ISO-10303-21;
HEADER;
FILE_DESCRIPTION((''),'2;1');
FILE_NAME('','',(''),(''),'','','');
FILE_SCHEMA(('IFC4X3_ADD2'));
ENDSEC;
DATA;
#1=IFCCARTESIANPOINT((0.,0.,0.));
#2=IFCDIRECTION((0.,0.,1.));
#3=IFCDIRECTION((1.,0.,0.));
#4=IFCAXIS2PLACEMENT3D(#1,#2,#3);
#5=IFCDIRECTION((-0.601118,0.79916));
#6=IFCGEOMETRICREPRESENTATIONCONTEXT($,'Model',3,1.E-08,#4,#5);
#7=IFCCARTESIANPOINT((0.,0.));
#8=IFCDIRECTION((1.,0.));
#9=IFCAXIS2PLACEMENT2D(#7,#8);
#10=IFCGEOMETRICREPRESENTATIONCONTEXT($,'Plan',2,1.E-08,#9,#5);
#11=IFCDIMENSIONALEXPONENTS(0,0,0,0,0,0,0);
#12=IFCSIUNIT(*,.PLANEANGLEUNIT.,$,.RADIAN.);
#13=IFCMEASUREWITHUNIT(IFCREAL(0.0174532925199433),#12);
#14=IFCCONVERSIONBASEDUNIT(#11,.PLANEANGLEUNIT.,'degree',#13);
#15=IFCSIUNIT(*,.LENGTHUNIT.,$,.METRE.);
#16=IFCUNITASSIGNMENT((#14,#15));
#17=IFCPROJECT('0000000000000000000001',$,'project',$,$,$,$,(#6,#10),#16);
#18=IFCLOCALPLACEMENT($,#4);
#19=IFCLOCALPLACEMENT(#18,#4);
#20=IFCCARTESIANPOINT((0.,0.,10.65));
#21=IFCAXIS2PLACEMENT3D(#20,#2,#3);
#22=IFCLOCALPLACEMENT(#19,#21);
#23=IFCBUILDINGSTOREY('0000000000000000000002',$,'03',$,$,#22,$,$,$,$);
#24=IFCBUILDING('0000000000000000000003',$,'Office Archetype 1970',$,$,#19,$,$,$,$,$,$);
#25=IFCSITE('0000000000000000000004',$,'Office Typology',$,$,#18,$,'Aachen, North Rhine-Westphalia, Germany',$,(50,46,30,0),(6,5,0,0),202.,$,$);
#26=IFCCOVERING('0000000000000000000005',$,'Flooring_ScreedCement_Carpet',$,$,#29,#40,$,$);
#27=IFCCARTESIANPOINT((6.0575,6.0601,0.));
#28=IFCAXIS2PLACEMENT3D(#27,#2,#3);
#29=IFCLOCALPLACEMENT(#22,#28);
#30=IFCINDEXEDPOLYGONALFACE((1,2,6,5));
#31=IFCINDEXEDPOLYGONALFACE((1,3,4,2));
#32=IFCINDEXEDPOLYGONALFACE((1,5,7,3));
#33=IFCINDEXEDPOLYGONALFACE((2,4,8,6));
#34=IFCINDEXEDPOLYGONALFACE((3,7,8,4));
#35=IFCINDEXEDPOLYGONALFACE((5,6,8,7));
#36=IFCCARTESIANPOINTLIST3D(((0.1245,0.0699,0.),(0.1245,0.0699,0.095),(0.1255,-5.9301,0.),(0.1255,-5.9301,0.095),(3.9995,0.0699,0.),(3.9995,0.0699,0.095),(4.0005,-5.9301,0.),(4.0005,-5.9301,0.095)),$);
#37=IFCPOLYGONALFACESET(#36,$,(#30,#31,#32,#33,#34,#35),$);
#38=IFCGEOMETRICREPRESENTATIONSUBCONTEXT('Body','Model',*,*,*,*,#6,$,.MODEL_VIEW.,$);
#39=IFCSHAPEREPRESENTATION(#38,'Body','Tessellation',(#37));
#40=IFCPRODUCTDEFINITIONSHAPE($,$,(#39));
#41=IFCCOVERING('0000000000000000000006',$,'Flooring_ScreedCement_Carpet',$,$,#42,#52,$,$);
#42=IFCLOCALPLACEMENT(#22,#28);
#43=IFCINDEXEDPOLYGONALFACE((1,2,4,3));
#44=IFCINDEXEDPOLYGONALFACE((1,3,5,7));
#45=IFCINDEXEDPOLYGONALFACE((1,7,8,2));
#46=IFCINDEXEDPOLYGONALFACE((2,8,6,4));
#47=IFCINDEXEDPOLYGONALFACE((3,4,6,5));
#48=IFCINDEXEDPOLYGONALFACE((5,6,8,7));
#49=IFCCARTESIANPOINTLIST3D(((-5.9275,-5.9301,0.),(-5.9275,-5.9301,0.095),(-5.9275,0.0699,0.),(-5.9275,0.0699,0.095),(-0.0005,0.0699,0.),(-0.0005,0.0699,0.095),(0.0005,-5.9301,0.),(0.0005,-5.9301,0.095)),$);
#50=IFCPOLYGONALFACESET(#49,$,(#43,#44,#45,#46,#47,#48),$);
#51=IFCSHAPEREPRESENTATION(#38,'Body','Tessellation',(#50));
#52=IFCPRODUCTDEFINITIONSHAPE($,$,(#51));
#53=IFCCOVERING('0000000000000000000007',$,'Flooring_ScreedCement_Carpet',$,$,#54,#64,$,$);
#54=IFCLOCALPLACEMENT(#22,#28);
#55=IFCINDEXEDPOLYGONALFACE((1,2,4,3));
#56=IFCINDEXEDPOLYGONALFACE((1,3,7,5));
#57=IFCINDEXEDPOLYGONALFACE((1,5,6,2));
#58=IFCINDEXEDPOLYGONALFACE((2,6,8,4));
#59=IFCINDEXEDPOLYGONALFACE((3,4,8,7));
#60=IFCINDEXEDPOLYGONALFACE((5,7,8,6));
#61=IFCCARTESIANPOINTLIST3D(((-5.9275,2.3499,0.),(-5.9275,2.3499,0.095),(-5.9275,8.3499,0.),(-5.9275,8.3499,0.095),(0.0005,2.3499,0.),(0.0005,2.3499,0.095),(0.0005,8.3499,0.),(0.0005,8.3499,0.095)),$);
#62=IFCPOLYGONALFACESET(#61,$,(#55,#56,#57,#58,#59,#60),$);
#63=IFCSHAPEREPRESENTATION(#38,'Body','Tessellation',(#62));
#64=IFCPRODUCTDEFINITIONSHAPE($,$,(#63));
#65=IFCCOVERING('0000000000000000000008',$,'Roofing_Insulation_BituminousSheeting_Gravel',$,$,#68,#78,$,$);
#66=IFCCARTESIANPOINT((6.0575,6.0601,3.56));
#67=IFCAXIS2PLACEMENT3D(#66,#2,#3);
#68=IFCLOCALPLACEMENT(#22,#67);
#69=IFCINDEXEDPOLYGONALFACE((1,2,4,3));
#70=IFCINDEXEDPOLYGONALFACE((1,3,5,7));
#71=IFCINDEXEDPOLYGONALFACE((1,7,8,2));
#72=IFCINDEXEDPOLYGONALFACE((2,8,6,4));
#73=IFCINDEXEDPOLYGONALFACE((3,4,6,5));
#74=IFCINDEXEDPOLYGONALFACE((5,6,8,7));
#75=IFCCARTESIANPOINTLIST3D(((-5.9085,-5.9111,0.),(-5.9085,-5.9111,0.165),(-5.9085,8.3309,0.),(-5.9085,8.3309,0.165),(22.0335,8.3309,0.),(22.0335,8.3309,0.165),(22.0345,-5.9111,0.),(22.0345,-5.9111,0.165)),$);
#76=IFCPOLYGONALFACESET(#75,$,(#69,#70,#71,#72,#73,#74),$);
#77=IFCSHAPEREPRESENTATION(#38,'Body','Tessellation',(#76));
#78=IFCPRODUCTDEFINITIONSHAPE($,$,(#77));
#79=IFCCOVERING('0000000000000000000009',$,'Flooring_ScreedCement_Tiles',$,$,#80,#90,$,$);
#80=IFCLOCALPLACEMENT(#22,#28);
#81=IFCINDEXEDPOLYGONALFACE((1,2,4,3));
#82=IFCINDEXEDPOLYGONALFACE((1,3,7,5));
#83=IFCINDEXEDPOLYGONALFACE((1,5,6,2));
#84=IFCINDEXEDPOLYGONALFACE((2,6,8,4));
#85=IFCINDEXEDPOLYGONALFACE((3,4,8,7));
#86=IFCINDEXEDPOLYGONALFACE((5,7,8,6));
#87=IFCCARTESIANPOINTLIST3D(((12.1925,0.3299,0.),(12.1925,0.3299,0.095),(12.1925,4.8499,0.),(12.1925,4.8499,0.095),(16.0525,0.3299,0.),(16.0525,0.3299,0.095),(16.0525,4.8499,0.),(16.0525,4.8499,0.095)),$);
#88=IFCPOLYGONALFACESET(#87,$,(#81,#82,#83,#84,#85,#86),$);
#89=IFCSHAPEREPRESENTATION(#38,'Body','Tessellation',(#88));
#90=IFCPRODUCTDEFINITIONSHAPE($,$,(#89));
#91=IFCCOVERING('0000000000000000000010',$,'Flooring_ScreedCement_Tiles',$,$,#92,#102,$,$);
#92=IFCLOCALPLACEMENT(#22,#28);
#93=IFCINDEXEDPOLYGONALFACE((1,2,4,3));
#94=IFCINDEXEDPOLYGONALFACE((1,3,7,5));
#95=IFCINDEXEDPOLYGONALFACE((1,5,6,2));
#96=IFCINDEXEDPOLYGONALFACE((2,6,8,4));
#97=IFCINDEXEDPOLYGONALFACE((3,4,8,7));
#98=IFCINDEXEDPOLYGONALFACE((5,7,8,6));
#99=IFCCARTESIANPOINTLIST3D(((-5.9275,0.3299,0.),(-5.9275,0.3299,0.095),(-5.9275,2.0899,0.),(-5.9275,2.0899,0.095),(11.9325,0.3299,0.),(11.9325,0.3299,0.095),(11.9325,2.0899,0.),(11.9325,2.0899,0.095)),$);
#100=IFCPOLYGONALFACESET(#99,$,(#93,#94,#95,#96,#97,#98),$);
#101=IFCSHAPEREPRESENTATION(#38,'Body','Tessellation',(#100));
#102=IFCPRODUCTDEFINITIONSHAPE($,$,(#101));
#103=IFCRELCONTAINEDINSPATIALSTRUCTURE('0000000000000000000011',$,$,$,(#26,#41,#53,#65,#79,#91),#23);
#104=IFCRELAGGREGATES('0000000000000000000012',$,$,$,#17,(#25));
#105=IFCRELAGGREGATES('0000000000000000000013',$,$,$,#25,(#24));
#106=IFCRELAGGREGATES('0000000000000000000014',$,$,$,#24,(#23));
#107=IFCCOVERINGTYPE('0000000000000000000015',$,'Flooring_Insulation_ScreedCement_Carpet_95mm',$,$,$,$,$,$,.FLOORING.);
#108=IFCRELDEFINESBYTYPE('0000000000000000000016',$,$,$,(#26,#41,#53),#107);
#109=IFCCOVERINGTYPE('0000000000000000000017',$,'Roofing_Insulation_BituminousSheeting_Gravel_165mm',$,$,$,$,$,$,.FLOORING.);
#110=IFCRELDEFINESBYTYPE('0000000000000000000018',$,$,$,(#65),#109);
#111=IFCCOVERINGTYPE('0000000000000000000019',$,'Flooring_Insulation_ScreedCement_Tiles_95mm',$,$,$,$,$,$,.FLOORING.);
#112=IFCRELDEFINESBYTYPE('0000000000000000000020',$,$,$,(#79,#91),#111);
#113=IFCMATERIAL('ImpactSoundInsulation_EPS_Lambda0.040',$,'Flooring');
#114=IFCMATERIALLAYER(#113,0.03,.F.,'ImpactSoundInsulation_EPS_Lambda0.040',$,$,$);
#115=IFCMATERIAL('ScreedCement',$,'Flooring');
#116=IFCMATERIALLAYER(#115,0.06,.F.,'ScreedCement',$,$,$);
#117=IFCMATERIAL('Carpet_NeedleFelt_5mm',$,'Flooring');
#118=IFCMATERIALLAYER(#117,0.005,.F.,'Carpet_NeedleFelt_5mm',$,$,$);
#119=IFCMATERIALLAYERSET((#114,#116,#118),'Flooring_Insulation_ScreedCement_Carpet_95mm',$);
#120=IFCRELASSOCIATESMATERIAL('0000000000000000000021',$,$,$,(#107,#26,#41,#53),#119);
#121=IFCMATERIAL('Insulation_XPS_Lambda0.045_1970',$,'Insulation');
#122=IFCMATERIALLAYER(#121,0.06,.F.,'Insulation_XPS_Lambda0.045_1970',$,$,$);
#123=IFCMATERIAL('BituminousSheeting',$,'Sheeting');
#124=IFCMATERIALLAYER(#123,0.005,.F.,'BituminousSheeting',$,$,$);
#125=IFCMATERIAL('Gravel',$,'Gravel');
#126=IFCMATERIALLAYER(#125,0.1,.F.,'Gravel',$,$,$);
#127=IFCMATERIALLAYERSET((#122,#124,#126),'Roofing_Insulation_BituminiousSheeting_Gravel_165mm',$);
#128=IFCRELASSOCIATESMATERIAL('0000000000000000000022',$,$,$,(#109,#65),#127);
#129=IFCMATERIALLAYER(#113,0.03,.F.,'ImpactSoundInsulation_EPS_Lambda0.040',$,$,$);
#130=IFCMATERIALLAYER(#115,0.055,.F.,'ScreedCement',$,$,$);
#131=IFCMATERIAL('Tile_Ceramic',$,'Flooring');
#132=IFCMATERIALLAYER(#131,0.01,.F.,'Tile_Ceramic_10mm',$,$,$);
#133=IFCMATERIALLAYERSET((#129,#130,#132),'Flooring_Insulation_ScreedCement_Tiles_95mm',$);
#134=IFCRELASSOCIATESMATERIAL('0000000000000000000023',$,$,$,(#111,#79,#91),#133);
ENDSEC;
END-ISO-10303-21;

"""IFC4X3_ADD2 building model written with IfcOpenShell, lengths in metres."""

from ifc_helpers import new_model, entity, si_unit, converted_unit, direction, frame, origin_with_axes, origin_2d_with_axis, place, context, subcontext, project, spatial, line, indexed_curve, outline, extrude, material, layer, layer_set, layer_usage, type_object, element, save


model = new_model("IFC4X3_ADD2")

# Units and contexts
model_context = context("Model", 3, precision=1e-08, world=origin_with_axes(), true_north=direction((-0.601118, 0.79916)))
plan_context = context("Plan", 2, precision=1e-08, world=origin_2d_with_axis(), true_north=direction((-0.601118, 0.79916)))
body_context = subcontext(model_context, "Body", "Model", "MODEL_VIEW")
ifc_project = project(units=[converted_unit("PLANEANGLEUNIT", "degree", entity("IfcReal", 0.0174532925199433), si_unit("PLANEANGLEUNIT", "RADIAN"), dimensions=[0, 0, 0, 0, 0, 0, 0]), si_unit("LENGTHUNIT", "METRE")], contexts=[model_context, plan_context])

# Site, building, storey
site_placement = place(None, origin_with_axes())
site = spatial("IfcSite", under=ifc_project, at=site_placement, Name="Office Typology", LongName="Aachen, North Rhine-Westphalia, Germany", RefLatitude=(50, 46, 30, 0), RefLongitude=(6, 5, 0, 0), RefElevation=202.0)
building_placement = place(site_placement, origin_with_axes())
building = spatial("IfcBuilding", under=site, at=building_placement, Name="Office Archetype 1970")
storey_placement = place(building_placement, frame((0.0, 0.0, 10.65), z_axis=(0.0, 0.0, 1.0), x_axis=(1.0, 0.0, 0.0)))
storey = spatial("IfcBuildingStorey", under=building, at=storey_placement, Name="03")

# Coverings
ifc_material_1 = material(Name="ImpactSoundInsulation_EPS_Lambda0.040", Category="Flooring")
ifc_layer_1 = layer(ifc_material_1, 0.03, ventilated=False, Name="ImpactSoundInsulation_EPS_Lambda0.040")
ifc_material_2 = material(Name="ScreedCement", Category="Flooring")
ifc_layer_2 = layer(ifc_material_2, 0.06, ventilated=False, Name="ScreedCement")
ifc_material_3 = material(Name="Carpet_NeedleFelt_5mm", Category="Flooring")
ifc_layer_3 = layer(ifc_material_3, 0.005, ventilated=False, Name="Carpet_NeedleFelt_5mm")
ifc_layer_set_1 = layer_set([ifc_layer_1, ifc_layer_2, ifc_layer_3], Name="Flooring_Insulation_ScreedCement_Carpet_95mm")
ifc_layer_usage_1 = layer_usage(ifc_layer_set_1, "AXIS3", "POSITIVE", 0.0)
covering_type_1 = type_object("IfcCoveringType", Name="Flooring_Insulation_ScreedCement_Carpet_95mm", PredefinedType="FLOORING", material=ifc_layer_set_1)
covering_1_placement = place(storey_placement, frame((6.0575, 6.0601, 0.0), z_axis=(0.0, 0.0, 1.0), x_axis=(1.0, 0.0, 0.0)))
element("IfcCovering", 1, at=covering_1_placement, inside=storey, type_object=covering_type_1, material=ifc_layer_usage_1, Name="Flooring_ScreedCement_Carpet", context=body_context, shape_type="SweptSolid", body=[
    extrude(outline(indexed_curve([(0.1255, -5.9301), (0.1245, 0.0699), (3.9995, 0.0699), (4.0005, -5.9301)], segments=[line(1, 2, 3, 4, 1)])), origin_with_axes(), (0.0, 0.0, 1.0), 0.095),
])
ifc_layer_usage_2 = layer_usage(ifc_layer_set_1, "AXIS3", "POSITIVE", 0.0)
covering_2_placement = place(storey_placement, frame((6.0575, 6.0601, 0.0), z_axis=(0.0, 0.0, 1.0), x_axis=(1.0, 0.0, 0.0)))
element("IfcCovering", 2, at=covering_2_placement, inside=storey, type_object=covering_type_1, material=ifc_layer_usage_2, Name="Flooring_ScreedCement_Carpet", context=body_context, shape_type="SweptSolid", body=[
    extrude(outline(indexed_curve([(-5.9275, -5.9301), (-5.9275, 0.0699), (-0.0005, 0.0699), (0.0005, -5.9301)], segments=[line(1, 2, 3, 4, 1)])), origin_with_axes(), (0.0, 0.0, 1.0), 0.095),
])
ifc_layer_usage_3 = layer_usage(ifc_layer_set_1, "AXIS3", "POSITIVE", 0.0)
covering_3_placement = place(storey_placement, frame((6.0575, 6.0601, 0.0), z_axis=(0.0, 0.0, 1.0), x_axis=(1.0, 0.0, 0.0)))
element("IfcCovering", 3, at=covering_3_placement, inside=storey, type_object=covering_type_1, material=ifc_layer_usage_3, Name="Flooring_ScreedCement_Carpet", context=body_context, shape_type="SweptSolid", body=[
    extrude(outline(indexed_curve([(0.0005, 2.3499), (-5.9275, 2.3499), (-5.9275, 8.3499), (0.0005, 8.3499)], segments=[line(1, 2, 3, 4, 1)])), origin_with_axes(), (0.0, 0.0, 1.0), 0.095),
])
ifc_material_4 = material(Name="Insulation_XPS_Lambda0.045_1970", Category="Insulation")
ifc_layer_4 = layer(ifc_material_4, 0.06, ventilated=False, Name="Insulation_XPS_Lambda0.045_1970")
ifc_material_5 = material(Name="BituminousSheeting", Category="Sheeting")
ifc_layer_5 = layer(ifc_material_5, 0.005, ventilated=False, Name="BituminousSheeting")
ifc_material_6 = material(Name="Gravel", Category="Gravel")
ifc_layer_6 = layer(ifc_material_6, 0.1, ventilated=False, Name="Gravel")
ifc_layer_set_2 = layer_set([ifc_layer_4, ifc_layer_5, ifc_layer_6], Name="Roofing_Insulation_BituminiousSheeting_Gravel_165mm")
ifc_layer_usage_4 = layer_usage(ifc_layer_set_2, "AXIS3", "POSITIVE", 0.0)
covering_type_2 = type_object("IfcCoveringType", Name="Roofing_Insulation_BituminousSheeting_Gravel_165mm", PredefinedType="FLOORING", material=ifc_layer_set_2)
covering_4_placement = place(storey_placement, frame((6.0575, 6.0601, 3.56), z_axis=(0.0, 0.0, 1.0), x_axis=(1.0, 0.0, 0.0)))
element("IfcCovering", 4, at=covering_4_placement, inside=storey, type_object=covering_type_2, material=ifc_layer_usage_4, Name="Roofing_Insulation_BituminousSheeting_Gravel", context=body_context, shape_type="SweptSolid", body=[
    extrude(outline(indexed_curve([(22.0345, -5.9111), (22.0335, 8.3309), (-5.9085, 8.3309), (-5.9085, -5.9111), (22.0345, -5.9111)])), None, (0.0, 0.0, 1.0), 0.165),
])
ifc_layer_7 = layer(ifc_material_1, 0.03, ventilated=False, Name="ImpactSoundInsulation_EPS_Lambda0.040")
ifc_layer_8 = layer(ifc_material_2, 0.055, ventilated=False, Name="ScreedCement")
ifc_material_7 = material(Name="Tile_Ceramic", Category="Flooring")
ifc_layer_9 = layer(ifc_material_7, 0.01, ventilated=False, Name="Tile_Ceramic_10mm")
ifc_layer_set_3 = layer_set([ifc_layer_7, ifc_layer_8, ifc_layer_9], Name="Flooring_Insulation_ScreedCement_Tiles_95mm")
ifc_layer_usage_5 = layer_usage(ifc_layer_set_3, "AXIS3", "POSITIVE", 0.0)
covering_type_3 = type_object("IfcCoveringType", Name="Flooring_Insulation_ScreedCement_Tiles_95mm", PredefinedType="FLOORING", material=ifc_layer_set_3)
covering_5_placement = place(storey_placement, frame((6.0575, 6.0601, 0.0), z_axis=(0.0, 0.0, 1.0), x_axis=(1.0, 0.0, 0.0)))
element("IfcCovering", 5, at=covering_5_placement, inside=storey, type_object=covering_type_3, material=ifc_layer_usage_5, Name="Flooring_ScreedCement_Tiles", context=body_context, shape_type="SweptSolid", body=[
    extrude(outline(indexed_curve([(16.0525, 0.3299), (12.1925, 0.3299), (12.1925, 4.8499), (16.0525, 4.8499)], segments=[line(1, 2, 3, 4, 1)])), origin_with_axes(), (0.0, 0.0, 1.0), 0.095),
])
ifc_layer_usage_6 = layer_usage(ifc_layer_set_3, "AXIS3", "POSITIVE", 0.0)
covering_6_placement = place(storey_placement, frame((6.0575, 6.0601, 0.0), z_axis=(0.0, 0.0, 1.0), x_axis=(1.0, 0.0, 0.0)))
element("IfcCovering", 6, at=covering_6_placement, inside=storey, type_object=covering_type_3, material=ifc_layer_usage_6, Name="Flooring_ScreedCement_Tiles", context=body_context, shape_type="SweptSolid", body=[
    extrude(outline(indexed_curve([(-5.9275, 0.3299), (-5.9275, 2.0899), (11.9325, 2.0899), (11.9325, 0.3299)], segments=[line(1, 2, 3, 4, 1)])), None, (0.0, 0.0, 1.0), 0.095),
])

save(model, "model.ifc")
